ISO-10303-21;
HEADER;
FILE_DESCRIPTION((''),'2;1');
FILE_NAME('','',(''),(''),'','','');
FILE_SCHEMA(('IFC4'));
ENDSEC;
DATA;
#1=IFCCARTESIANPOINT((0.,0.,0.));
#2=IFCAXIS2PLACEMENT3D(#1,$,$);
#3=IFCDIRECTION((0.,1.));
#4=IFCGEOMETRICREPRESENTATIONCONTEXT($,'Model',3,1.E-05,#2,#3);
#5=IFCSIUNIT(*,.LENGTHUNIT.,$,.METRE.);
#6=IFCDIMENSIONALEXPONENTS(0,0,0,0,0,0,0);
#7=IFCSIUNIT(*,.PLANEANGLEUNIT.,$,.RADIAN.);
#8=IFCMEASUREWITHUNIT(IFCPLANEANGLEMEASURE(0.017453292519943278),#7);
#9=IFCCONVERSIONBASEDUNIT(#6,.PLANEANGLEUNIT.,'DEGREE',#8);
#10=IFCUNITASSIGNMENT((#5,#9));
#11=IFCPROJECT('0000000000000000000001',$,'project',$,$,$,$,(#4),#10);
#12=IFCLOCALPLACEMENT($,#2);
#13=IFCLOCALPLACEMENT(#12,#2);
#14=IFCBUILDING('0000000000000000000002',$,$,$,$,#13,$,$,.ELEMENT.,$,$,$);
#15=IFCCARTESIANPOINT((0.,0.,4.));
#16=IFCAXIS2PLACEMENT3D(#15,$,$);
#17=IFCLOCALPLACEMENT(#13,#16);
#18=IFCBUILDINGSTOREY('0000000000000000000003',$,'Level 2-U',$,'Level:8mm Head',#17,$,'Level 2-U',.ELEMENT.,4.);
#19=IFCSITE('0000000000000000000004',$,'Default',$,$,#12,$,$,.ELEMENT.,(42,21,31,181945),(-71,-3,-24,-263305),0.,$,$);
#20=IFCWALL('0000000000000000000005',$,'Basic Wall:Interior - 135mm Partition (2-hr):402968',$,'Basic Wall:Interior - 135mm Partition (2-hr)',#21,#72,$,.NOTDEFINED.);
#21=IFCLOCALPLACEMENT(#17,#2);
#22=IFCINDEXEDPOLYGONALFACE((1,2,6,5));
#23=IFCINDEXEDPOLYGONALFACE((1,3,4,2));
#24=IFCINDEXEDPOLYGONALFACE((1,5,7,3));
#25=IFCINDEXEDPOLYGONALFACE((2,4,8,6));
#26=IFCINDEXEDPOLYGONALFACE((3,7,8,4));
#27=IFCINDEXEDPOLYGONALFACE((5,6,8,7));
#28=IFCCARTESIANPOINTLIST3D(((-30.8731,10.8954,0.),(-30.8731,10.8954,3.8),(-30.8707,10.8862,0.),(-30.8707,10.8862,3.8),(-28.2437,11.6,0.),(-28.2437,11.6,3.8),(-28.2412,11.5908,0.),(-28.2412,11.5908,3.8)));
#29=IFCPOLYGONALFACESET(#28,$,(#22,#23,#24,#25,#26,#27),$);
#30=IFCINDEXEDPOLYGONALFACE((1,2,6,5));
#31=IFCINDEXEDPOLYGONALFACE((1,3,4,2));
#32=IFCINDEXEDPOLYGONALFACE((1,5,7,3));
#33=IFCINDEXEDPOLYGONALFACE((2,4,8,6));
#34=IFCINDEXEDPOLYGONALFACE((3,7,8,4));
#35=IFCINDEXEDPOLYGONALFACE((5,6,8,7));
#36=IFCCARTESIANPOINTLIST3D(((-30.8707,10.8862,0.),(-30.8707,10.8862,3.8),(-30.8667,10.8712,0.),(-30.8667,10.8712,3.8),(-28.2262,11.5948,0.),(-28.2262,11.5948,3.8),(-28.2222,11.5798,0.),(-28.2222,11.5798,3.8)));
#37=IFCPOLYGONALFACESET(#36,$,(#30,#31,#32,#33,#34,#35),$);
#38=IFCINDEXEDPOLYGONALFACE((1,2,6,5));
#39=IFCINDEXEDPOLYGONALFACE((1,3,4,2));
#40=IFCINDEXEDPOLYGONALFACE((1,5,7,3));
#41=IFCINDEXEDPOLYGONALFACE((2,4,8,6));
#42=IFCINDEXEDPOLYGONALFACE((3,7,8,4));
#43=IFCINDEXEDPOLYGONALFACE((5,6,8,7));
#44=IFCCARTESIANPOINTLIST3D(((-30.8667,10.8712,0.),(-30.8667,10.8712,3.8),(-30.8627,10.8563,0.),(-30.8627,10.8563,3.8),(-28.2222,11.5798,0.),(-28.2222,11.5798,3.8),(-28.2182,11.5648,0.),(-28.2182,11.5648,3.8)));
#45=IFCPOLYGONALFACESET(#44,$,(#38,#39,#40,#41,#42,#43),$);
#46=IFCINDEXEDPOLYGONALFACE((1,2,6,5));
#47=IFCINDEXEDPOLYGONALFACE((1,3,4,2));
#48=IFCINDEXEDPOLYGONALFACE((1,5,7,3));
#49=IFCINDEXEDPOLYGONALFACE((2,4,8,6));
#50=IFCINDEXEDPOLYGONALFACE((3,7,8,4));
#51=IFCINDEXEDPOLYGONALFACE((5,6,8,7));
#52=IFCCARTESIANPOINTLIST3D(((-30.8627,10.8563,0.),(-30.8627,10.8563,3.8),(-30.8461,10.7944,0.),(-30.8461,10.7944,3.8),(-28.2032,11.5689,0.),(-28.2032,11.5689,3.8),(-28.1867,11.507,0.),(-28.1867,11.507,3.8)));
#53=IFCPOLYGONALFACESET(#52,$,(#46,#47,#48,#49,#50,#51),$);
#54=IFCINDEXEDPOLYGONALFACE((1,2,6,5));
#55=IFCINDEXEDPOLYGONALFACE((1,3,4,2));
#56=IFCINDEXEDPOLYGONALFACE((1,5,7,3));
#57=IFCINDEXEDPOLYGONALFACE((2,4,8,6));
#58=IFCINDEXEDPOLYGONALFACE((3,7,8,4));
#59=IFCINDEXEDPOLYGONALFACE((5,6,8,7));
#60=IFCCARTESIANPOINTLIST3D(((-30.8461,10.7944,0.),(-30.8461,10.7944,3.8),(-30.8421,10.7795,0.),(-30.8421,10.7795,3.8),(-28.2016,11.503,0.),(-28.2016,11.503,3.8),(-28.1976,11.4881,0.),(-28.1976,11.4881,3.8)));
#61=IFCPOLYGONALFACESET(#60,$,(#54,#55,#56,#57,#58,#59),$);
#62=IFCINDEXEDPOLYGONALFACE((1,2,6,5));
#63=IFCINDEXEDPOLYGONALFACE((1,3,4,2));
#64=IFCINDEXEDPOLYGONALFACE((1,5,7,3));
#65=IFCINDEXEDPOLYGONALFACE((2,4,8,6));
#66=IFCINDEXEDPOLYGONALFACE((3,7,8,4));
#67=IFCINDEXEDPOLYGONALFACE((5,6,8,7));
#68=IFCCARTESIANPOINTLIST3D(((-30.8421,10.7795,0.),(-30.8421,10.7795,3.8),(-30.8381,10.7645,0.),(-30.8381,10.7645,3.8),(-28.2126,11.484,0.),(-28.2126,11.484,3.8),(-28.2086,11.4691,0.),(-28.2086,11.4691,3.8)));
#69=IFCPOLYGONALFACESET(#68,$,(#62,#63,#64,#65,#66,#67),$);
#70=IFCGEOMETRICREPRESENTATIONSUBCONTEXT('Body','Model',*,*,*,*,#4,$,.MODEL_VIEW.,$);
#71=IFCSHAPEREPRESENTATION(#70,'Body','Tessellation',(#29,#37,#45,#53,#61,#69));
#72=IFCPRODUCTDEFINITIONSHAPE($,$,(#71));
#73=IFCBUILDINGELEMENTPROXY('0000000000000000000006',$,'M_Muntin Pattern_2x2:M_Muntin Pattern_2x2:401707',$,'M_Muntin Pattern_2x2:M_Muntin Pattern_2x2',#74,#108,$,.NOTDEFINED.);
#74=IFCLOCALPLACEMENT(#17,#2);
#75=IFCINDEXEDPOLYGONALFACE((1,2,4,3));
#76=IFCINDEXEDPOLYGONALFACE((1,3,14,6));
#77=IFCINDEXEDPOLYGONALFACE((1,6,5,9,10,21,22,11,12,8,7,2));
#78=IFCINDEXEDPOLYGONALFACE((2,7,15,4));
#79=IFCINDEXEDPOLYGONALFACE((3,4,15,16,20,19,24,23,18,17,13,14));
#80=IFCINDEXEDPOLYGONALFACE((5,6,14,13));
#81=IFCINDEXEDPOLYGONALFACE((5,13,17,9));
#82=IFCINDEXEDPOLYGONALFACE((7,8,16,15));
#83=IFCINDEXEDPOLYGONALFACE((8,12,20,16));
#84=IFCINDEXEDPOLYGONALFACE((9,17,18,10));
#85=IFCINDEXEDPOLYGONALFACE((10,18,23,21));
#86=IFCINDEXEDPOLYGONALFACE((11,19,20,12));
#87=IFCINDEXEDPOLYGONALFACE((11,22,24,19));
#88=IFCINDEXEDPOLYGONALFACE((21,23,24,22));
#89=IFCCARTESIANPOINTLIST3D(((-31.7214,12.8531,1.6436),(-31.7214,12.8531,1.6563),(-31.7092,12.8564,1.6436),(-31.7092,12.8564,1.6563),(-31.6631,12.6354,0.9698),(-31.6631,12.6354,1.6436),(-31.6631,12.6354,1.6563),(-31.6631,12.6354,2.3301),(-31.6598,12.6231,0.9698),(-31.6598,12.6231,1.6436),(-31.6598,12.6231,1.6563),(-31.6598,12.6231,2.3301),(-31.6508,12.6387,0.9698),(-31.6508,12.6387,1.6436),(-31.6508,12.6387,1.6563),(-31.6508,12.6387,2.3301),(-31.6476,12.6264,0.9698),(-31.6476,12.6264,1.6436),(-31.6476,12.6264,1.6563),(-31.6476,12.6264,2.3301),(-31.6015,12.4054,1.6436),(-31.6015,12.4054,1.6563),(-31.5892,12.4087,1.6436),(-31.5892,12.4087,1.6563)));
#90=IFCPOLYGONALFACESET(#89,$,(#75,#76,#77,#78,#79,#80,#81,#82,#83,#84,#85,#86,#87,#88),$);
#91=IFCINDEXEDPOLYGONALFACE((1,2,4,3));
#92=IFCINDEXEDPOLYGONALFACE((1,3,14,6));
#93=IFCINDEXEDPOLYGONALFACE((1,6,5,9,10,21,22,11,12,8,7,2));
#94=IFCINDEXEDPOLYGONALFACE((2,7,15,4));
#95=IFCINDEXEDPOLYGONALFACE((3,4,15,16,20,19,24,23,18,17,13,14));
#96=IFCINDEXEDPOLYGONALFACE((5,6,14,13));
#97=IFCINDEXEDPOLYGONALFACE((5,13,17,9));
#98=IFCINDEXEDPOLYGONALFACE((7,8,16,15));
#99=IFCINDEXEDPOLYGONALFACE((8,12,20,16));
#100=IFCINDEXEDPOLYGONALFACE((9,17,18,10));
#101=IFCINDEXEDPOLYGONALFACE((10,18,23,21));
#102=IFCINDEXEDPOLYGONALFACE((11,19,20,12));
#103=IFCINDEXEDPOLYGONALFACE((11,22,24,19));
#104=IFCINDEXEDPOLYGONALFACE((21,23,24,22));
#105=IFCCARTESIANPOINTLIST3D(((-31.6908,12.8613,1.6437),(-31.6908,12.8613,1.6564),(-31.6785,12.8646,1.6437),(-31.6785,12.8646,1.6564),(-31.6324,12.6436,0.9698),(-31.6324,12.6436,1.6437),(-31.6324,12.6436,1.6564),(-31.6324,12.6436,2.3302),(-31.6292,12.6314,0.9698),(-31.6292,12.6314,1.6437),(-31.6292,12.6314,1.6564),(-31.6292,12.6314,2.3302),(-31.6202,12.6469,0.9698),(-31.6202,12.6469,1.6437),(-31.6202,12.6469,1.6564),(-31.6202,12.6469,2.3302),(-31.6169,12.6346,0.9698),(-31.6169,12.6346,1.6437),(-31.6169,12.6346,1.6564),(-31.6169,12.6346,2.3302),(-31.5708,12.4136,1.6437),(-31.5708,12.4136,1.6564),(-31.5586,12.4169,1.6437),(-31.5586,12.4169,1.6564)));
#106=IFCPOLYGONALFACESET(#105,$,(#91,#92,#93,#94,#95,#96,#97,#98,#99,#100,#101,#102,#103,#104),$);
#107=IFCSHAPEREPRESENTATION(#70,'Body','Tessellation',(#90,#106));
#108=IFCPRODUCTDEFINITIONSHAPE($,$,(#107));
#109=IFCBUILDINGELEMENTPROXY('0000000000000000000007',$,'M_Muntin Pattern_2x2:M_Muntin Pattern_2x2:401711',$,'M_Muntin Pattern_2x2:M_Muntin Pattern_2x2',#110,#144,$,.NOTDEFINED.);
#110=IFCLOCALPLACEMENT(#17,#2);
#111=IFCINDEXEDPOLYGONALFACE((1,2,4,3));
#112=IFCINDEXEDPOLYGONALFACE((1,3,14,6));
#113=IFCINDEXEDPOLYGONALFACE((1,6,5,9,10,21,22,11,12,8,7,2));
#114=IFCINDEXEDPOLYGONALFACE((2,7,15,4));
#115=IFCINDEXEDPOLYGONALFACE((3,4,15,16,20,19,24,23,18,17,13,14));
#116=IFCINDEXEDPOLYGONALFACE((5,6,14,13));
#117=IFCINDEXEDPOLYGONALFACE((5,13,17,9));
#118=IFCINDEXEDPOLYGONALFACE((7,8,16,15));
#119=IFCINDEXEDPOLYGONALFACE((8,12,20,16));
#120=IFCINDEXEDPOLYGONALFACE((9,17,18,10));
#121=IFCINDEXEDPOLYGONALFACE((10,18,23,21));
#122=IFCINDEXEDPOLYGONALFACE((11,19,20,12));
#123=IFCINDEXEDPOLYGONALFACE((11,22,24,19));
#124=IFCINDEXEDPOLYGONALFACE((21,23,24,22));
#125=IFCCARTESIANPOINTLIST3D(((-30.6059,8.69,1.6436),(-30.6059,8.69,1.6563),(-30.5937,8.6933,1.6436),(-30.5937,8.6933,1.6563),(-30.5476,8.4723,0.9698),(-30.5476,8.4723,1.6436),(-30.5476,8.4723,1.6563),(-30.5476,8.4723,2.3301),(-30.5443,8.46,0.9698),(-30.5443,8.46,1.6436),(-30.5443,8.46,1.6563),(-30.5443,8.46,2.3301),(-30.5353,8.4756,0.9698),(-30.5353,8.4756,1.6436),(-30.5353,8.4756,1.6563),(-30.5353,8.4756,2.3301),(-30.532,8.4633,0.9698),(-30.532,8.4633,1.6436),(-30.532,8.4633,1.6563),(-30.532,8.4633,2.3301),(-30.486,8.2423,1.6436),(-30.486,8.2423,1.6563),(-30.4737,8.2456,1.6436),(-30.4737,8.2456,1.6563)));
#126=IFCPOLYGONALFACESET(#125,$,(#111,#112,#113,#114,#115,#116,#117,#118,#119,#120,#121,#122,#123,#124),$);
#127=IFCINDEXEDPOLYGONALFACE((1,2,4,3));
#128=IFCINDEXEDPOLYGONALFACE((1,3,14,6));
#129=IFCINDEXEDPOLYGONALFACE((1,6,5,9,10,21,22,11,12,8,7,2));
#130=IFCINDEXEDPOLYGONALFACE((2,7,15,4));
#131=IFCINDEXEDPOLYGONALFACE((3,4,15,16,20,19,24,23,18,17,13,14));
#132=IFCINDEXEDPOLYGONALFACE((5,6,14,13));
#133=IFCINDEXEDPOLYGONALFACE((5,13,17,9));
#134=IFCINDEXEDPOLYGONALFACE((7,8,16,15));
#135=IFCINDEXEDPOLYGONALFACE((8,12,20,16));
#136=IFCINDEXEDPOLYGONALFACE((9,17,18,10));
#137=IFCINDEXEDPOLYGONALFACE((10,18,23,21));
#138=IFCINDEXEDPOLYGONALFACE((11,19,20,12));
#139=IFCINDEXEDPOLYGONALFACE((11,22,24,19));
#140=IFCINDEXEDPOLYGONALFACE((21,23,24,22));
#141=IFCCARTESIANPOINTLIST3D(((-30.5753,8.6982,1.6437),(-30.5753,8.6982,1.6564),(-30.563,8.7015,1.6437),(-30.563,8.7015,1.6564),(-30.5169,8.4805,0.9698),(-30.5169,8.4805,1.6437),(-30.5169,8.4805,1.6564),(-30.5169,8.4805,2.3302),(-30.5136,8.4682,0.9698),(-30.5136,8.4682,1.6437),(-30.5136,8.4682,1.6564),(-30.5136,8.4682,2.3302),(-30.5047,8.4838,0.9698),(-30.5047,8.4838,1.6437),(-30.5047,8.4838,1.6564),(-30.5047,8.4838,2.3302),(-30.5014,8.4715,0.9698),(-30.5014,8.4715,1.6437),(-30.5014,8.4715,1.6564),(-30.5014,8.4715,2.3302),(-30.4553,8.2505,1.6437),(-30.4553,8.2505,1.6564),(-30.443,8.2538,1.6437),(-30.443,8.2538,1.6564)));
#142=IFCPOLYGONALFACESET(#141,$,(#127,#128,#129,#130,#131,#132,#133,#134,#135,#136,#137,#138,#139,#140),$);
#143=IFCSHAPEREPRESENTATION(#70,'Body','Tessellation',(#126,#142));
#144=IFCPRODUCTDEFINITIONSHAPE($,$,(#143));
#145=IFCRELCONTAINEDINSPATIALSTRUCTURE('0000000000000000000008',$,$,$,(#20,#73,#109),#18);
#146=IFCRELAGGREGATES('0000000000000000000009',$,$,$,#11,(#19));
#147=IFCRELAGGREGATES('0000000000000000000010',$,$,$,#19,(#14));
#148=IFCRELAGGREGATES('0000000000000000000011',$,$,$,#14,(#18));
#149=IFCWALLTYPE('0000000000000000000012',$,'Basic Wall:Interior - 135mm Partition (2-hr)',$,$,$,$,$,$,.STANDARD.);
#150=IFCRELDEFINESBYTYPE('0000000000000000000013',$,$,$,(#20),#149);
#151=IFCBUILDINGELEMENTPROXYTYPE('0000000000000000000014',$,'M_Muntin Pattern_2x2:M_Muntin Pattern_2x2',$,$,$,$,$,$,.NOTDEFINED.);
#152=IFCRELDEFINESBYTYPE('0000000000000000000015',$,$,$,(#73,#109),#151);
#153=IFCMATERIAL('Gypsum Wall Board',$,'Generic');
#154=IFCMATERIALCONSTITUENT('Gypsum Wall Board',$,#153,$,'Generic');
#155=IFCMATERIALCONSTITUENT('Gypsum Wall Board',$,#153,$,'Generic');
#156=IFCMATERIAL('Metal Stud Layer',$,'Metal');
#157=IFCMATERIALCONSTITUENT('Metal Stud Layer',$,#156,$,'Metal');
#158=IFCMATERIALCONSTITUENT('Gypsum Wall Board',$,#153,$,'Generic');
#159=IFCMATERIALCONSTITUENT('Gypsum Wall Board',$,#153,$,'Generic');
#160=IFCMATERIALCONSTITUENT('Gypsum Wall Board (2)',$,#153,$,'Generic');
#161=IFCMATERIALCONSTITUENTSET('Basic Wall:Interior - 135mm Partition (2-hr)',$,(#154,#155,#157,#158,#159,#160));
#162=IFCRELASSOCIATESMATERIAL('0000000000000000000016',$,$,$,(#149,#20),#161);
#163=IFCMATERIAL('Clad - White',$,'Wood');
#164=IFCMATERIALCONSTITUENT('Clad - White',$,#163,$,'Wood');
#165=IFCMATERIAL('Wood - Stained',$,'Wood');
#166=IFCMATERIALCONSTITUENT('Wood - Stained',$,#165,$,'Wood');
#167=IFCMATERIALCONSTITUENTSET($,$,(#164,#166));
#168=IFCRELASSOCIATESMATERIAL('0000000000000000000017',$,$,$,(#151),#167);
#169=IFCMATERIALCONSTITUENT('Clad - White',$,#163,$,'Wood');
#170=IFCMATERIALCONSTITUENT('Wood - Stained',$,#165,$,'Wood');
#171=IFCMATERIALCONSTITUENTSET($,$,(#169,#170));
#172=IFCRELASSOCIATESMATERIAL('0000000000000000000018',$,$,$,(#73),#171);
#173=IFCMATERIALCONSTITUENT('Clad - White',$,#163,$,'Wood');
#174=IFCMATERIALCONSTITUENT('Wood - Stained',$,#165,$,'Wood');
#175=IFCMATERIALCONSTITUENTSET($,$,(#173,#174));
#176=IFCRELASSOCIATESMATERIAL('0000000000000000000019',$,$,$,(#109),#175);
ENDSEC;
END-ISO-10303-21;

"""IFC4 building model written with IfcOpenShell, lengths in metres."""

from ifc_helpers import new_model, entity, si_unit, converted_unit, direction, frame, origin, place, context, subcontext, project, spatial, indexed_curve, outline, extrude, source, transform, mapped, material, constituent, constituent_set, type_object, type_shapes, element, save


model = new_model("IFC4")

# Units and contexts
model_context = context("Model", 3, precision=1e-05, world=origin(), true_north=direction((0.0, 1.0)))
body_context = subcontext(model_context, "Body", "Model", "MODEL_VIEW")
ifc_project = project(units=[si_unit("LENGTHUNIT", "METRE"), converted_unit("PLANEANGLEUNIT", "DEGREE", entity("IfcPlaneAngleMeasure", 0.017453292519943278), si_unit("PLANEANGLEUNIT", "RADIAN"), dimensions=[0, 0, 0, 0, 0, 0, 0])], contexts=[model_context])

# Site, building, storey
site_placement = place(None, origin())
site = spatial("IfcSite", under=ifc_project, at=site_placement, Name="Default", CompositionType="ELEMENT", RefLatitude=(42, 21, 31, 181945), RefLongitude=(-71, -3, -24, -263305), RefElevation=0.0)
building_placement = place(site_placement, origin())
building = spatial("IfcBuilding", under=site, at=building_placement, CompositionType="ELEMENT")
storey_placement = place(building_placement, frame((0.0, 0.0, 4.0)))
storey = spatial("IfcBuildingStorey", under=building, at=storey_placement, Name="Level 2-U", ObjectType="Level:8mm Head", LongName="Level 2-U", CompositionType="ELEMENT", Elevation=4.0)

# Shared definitions
ifc_material_1 = material(Name="Gypsum Wall Board", Category="Generic")
ifc_constituent_1 = constituent(ifc_material_1, Name="Gypsum Wall Board", Category="Generic")
ifc_constituent_2 = constituent(ifc_material_1, Name="Gypsum Wall Board", Category="Generic")
ifc_material_2 = material(Name="Metal Stud Layer", Category="Metal")
ifc_constituent_3 = constituent(ifc_material_2, Name="Metal Stud Layer", Category="Metal")
ifc_constituent_4 = constituent(ifc_material_1, Name="Gypsum Wall Board", Category="Generic")
ifc_constituent_5 = constituent(ifc_material_1, Name="Gypsum Wall Board", Category="Generic")
ifc_constituent_6 = constituent(ifc_material_1, Name="Gypsum Wall Board (2)", Category="Generic")
ifc_constituent_set_1 = constituent_set(constituents=[ifc_constituent_1, ifc_constituent_2, ifc_constituent_3, ifc_constituent_4, ifc_constituent_5, ifc_constituent_6], Name="Basic Wall:Interior - 135mm Partition (2-hr)")
wall_type_1 = type_object("IfcWallType", Name="Basic Wall:Interior - 135mm Partition (2-hr)", PredefinedType="STANDARD", material=ifc_constituent_set_1)

# Wall
wall_1_placement = place(storey_placement, frame((-28.2261, 11.5345, 0.0), z_axis=(0.0, 0.0, 1.0), x_axis=(-0.965926, -0.258819, 0.0)))
element("IfcWall", 1, at=wall_1_placement, inside=storey, type_object=wall_type_1, material=ifc_constituent_set_1, Name="Basic Wall:Interior - 135mm Partition (2-hr):402968", ObjectType="Basic Wall:Interior - 135mm Partition (2-hr)", PredefinedType="NOTDEFINED", context=body_context, shape_type="SweptSolid", body=[
    extrude(outline(indexed_curve([(-0.0047, -1.3611), (0.0048, -1.3611), (0.0047, 1.3611), (-0.0048, 1.3611), (-0.0047, -1.3611)], self_intersect=False)), frame((1.3611, -0.063, 0.0), z_axis=(0.0, 0.0, 1.0), x_axis=(0.0, 1.0, 0.0)), (0.0, 0.0, 1.0), 3.8),
    extrude(outline(indexed_curve([(-1.3689, -0.0077), (1.3689, -0.0078), (1.3689, 0.0077), (-1.3689, 0.0078), (-1.3689, -0.0077)], self_intersect=False)), frame((1.3534, -0.0505, 0.0)), (0.0, 0.0, 1.0), 3.8),
    extrude(outline(indexed_curve([(-1.3689, -0.0077), (1.3689, -0.0078), (1.3689, 0.0077), (-1.3689, 0.0078), (-1.3689, -0.0077)], self_intersect=False)), frame((1.3534, -0.035, 0.0)), (0.0, 0.0, 1.0), 3.8),
    extrude(outline(indexed_curve([(-1.3766, -0.032), (1.3766, -0.032), (1.3766, 0.032), (-1.3766, 0.032), (-1.3766, -0.032)], self_intersect=False)), frame((1.3456, 0.0048, 0.0)), (0.0, 0.0, 1.0), 3.8),
    extrude(outline(indexed_curve([(-1.3689, -0.0077), (1.3689, -0.0078), (1.3689, 0.0077), (-1.3689, 0.0078), (-1.3689, -0.0077)], self_intersect=False)), frame((1.3534, 0.0445, 0.0)), (0.0, 0.0, 1.0), 3.8),
    extrude(outline(indexed_curve([(-0.0078, -1.3611), (0.0077, -1.3611), (0.0078, 1.3611), (-0.0077, 1.3611), (-0.0078, -1.3611)], self_intersect=False)), frame((1.3611, 0.06, 0.0), z_axis=(0.0, 0.0, 1.0), x_axis=(0.0, -1.0, 0.0)), (0.0, 0.0, 1.0), 3.8),
])

# Building element proxies
ifc_material_3 = material(Name="Clad - White", Category="Wood")
ifc_constituent_7 = constituent(ifc_material_3, Name="Clad - White", Category="Wood")
ifc_material_4 = material(Name="Wood - Stained", Category="Wood")
ifc_constituent_8 = constituent(ifc_material_4, Name="Wood - Stained", Category="Wood")
ifc_constituent_set_2 = constituent_set(constituents=[ifc_constituent_7, ifc_constituent_8])
ifc_constituent_9 = constituent(ifc_material_3, Name="Clad - White", Category="Wood")
ifc_constituent_10 = constituent(ifc_material_4, Name="Wood - Stained", Category="Wood")
ifc_constituent_set_3 = constituent_set(constituents=[ifc_constituent_9, ifc_constituent_10])
building_element_proxy_type_1 = type_object("IfcBuildingElementProxyType", Name="M_Muntin Pattern_2x2:M_Muntin Pattern_2x2", PredefinedType="NOTDEFINED", material=ifc_constituent_set_3)
shared_shape_1 = source(origin(), body_context, "Body", "SweptSolid", [
    extrude(outline(indexed_curve([(0.0064, -0.0064), (0.6801, -0.0064), (0.6801, 0.0063), (0.0064, 0.0063), (0.0064, 0.2317), (-0.0063, 0.2317), (-0.0063, 0.0063), (-0.6802, 0.0063), (-0.6802, -0.0064), (-0.0063, -0.0064), (-0.0063, -0.2317), (0.0064, -0.2317), (0.0064, -0.0064)], self_intersect=False)), frame((0.0, 0.0095, 0.6801), z_axis=(0.0, 1.0, 0.0), x_axis=(0.0, 0.0, 1.0)), (0.0, 0.0, 1.0), 0.0127),
    extrude(outline(indexed_curve([(0.0064, -0.0064), (0.6802, -0.0064), (0.6802, 0.0063), (0.0064, 0.0063), (0.0064, 0.2317), (-0.0063, 0.2317), (-0.0063, 0.0063), (-0.6802, 0.0063), (-0.6802, -0.0064), (-0.0063, -0.0064), (-0.0063, -0.2317), (0.0064, -0.2317), (0.0064, -0.0064)], self_intersect=False)), frame((0.0, -0.0222, 0.6802), z_axis=(0.0, 1.0, 0.0), x_axis=(0.0, 0.0, 1.0)), (0.0, 0.0, 1.0), 0.0127),
])
type_shapes(building_element_proxy_type_1, [shared_shape_1])
proxy_1_placement = place(storey_placement, frame((-31.64, 12.635, 0.9698), z_axis=(0.0, 0.0, 1.0), x_axis=(-0.258819, 0.965926, 0.0)))
element("IfcBuildingElementProxy", 2, at=proxy_1_placement, inside=storey, type_object=building_element_proxy_type_1, material=ifc_constituent_set_2, Name="M_Muntin Pattern_2x2:M_Muntin Pattern_2x2:401707", ObjectType="M_Muntin Pattern_2x2:M_Muntin Pattern_2x2", PredefinedType="NOTDEFINED", context=body_context, shape_type="MappedRepresentation", body=[
    mapped(shared_shape_1, transform((0.0, 0.0, 0.0), scale=1.0)),
])
ifc_constituent_11 = constituent(ifc_material_3, Name="Clad - White", Category="Wood")
ifc_constituent_12 = constituent(ifc_material_4, Name="Wood - Stained", Category="Wood")
ifc_constituent_set_4 = constituent_set(constituents=[ifc_constituent_11, ifc_constituent_12])
proxy_2_placement = place(storey_placement, frame((-30.5245, 8.4719, 0.9698), z_axis=(0.0, 0.0, 1.0), x_axis=(-0.258819, 0.965926, 0.0)))
element("IfcBuildingElementProxy", 3, at=proxy_2_placement, inside=storey, type_object=building_element_proxy_type_1, material=ifc_constituent_set_4, Name="M_Muntin Pattern_2x2:M_Muntin Pattern_2x2:401711", ObjectType="M_Muntin Pattern_2x2:M_Muntin Pattern_2x2", PredefinedType="NOTDEFINED", context=body_context, shape_type="MappedRepresentation", body=[
    mapped(shared_shape_1, transform((0.0, 0.0, 0.0), scale=1.0)),
])

save(model, "model.ifc")
